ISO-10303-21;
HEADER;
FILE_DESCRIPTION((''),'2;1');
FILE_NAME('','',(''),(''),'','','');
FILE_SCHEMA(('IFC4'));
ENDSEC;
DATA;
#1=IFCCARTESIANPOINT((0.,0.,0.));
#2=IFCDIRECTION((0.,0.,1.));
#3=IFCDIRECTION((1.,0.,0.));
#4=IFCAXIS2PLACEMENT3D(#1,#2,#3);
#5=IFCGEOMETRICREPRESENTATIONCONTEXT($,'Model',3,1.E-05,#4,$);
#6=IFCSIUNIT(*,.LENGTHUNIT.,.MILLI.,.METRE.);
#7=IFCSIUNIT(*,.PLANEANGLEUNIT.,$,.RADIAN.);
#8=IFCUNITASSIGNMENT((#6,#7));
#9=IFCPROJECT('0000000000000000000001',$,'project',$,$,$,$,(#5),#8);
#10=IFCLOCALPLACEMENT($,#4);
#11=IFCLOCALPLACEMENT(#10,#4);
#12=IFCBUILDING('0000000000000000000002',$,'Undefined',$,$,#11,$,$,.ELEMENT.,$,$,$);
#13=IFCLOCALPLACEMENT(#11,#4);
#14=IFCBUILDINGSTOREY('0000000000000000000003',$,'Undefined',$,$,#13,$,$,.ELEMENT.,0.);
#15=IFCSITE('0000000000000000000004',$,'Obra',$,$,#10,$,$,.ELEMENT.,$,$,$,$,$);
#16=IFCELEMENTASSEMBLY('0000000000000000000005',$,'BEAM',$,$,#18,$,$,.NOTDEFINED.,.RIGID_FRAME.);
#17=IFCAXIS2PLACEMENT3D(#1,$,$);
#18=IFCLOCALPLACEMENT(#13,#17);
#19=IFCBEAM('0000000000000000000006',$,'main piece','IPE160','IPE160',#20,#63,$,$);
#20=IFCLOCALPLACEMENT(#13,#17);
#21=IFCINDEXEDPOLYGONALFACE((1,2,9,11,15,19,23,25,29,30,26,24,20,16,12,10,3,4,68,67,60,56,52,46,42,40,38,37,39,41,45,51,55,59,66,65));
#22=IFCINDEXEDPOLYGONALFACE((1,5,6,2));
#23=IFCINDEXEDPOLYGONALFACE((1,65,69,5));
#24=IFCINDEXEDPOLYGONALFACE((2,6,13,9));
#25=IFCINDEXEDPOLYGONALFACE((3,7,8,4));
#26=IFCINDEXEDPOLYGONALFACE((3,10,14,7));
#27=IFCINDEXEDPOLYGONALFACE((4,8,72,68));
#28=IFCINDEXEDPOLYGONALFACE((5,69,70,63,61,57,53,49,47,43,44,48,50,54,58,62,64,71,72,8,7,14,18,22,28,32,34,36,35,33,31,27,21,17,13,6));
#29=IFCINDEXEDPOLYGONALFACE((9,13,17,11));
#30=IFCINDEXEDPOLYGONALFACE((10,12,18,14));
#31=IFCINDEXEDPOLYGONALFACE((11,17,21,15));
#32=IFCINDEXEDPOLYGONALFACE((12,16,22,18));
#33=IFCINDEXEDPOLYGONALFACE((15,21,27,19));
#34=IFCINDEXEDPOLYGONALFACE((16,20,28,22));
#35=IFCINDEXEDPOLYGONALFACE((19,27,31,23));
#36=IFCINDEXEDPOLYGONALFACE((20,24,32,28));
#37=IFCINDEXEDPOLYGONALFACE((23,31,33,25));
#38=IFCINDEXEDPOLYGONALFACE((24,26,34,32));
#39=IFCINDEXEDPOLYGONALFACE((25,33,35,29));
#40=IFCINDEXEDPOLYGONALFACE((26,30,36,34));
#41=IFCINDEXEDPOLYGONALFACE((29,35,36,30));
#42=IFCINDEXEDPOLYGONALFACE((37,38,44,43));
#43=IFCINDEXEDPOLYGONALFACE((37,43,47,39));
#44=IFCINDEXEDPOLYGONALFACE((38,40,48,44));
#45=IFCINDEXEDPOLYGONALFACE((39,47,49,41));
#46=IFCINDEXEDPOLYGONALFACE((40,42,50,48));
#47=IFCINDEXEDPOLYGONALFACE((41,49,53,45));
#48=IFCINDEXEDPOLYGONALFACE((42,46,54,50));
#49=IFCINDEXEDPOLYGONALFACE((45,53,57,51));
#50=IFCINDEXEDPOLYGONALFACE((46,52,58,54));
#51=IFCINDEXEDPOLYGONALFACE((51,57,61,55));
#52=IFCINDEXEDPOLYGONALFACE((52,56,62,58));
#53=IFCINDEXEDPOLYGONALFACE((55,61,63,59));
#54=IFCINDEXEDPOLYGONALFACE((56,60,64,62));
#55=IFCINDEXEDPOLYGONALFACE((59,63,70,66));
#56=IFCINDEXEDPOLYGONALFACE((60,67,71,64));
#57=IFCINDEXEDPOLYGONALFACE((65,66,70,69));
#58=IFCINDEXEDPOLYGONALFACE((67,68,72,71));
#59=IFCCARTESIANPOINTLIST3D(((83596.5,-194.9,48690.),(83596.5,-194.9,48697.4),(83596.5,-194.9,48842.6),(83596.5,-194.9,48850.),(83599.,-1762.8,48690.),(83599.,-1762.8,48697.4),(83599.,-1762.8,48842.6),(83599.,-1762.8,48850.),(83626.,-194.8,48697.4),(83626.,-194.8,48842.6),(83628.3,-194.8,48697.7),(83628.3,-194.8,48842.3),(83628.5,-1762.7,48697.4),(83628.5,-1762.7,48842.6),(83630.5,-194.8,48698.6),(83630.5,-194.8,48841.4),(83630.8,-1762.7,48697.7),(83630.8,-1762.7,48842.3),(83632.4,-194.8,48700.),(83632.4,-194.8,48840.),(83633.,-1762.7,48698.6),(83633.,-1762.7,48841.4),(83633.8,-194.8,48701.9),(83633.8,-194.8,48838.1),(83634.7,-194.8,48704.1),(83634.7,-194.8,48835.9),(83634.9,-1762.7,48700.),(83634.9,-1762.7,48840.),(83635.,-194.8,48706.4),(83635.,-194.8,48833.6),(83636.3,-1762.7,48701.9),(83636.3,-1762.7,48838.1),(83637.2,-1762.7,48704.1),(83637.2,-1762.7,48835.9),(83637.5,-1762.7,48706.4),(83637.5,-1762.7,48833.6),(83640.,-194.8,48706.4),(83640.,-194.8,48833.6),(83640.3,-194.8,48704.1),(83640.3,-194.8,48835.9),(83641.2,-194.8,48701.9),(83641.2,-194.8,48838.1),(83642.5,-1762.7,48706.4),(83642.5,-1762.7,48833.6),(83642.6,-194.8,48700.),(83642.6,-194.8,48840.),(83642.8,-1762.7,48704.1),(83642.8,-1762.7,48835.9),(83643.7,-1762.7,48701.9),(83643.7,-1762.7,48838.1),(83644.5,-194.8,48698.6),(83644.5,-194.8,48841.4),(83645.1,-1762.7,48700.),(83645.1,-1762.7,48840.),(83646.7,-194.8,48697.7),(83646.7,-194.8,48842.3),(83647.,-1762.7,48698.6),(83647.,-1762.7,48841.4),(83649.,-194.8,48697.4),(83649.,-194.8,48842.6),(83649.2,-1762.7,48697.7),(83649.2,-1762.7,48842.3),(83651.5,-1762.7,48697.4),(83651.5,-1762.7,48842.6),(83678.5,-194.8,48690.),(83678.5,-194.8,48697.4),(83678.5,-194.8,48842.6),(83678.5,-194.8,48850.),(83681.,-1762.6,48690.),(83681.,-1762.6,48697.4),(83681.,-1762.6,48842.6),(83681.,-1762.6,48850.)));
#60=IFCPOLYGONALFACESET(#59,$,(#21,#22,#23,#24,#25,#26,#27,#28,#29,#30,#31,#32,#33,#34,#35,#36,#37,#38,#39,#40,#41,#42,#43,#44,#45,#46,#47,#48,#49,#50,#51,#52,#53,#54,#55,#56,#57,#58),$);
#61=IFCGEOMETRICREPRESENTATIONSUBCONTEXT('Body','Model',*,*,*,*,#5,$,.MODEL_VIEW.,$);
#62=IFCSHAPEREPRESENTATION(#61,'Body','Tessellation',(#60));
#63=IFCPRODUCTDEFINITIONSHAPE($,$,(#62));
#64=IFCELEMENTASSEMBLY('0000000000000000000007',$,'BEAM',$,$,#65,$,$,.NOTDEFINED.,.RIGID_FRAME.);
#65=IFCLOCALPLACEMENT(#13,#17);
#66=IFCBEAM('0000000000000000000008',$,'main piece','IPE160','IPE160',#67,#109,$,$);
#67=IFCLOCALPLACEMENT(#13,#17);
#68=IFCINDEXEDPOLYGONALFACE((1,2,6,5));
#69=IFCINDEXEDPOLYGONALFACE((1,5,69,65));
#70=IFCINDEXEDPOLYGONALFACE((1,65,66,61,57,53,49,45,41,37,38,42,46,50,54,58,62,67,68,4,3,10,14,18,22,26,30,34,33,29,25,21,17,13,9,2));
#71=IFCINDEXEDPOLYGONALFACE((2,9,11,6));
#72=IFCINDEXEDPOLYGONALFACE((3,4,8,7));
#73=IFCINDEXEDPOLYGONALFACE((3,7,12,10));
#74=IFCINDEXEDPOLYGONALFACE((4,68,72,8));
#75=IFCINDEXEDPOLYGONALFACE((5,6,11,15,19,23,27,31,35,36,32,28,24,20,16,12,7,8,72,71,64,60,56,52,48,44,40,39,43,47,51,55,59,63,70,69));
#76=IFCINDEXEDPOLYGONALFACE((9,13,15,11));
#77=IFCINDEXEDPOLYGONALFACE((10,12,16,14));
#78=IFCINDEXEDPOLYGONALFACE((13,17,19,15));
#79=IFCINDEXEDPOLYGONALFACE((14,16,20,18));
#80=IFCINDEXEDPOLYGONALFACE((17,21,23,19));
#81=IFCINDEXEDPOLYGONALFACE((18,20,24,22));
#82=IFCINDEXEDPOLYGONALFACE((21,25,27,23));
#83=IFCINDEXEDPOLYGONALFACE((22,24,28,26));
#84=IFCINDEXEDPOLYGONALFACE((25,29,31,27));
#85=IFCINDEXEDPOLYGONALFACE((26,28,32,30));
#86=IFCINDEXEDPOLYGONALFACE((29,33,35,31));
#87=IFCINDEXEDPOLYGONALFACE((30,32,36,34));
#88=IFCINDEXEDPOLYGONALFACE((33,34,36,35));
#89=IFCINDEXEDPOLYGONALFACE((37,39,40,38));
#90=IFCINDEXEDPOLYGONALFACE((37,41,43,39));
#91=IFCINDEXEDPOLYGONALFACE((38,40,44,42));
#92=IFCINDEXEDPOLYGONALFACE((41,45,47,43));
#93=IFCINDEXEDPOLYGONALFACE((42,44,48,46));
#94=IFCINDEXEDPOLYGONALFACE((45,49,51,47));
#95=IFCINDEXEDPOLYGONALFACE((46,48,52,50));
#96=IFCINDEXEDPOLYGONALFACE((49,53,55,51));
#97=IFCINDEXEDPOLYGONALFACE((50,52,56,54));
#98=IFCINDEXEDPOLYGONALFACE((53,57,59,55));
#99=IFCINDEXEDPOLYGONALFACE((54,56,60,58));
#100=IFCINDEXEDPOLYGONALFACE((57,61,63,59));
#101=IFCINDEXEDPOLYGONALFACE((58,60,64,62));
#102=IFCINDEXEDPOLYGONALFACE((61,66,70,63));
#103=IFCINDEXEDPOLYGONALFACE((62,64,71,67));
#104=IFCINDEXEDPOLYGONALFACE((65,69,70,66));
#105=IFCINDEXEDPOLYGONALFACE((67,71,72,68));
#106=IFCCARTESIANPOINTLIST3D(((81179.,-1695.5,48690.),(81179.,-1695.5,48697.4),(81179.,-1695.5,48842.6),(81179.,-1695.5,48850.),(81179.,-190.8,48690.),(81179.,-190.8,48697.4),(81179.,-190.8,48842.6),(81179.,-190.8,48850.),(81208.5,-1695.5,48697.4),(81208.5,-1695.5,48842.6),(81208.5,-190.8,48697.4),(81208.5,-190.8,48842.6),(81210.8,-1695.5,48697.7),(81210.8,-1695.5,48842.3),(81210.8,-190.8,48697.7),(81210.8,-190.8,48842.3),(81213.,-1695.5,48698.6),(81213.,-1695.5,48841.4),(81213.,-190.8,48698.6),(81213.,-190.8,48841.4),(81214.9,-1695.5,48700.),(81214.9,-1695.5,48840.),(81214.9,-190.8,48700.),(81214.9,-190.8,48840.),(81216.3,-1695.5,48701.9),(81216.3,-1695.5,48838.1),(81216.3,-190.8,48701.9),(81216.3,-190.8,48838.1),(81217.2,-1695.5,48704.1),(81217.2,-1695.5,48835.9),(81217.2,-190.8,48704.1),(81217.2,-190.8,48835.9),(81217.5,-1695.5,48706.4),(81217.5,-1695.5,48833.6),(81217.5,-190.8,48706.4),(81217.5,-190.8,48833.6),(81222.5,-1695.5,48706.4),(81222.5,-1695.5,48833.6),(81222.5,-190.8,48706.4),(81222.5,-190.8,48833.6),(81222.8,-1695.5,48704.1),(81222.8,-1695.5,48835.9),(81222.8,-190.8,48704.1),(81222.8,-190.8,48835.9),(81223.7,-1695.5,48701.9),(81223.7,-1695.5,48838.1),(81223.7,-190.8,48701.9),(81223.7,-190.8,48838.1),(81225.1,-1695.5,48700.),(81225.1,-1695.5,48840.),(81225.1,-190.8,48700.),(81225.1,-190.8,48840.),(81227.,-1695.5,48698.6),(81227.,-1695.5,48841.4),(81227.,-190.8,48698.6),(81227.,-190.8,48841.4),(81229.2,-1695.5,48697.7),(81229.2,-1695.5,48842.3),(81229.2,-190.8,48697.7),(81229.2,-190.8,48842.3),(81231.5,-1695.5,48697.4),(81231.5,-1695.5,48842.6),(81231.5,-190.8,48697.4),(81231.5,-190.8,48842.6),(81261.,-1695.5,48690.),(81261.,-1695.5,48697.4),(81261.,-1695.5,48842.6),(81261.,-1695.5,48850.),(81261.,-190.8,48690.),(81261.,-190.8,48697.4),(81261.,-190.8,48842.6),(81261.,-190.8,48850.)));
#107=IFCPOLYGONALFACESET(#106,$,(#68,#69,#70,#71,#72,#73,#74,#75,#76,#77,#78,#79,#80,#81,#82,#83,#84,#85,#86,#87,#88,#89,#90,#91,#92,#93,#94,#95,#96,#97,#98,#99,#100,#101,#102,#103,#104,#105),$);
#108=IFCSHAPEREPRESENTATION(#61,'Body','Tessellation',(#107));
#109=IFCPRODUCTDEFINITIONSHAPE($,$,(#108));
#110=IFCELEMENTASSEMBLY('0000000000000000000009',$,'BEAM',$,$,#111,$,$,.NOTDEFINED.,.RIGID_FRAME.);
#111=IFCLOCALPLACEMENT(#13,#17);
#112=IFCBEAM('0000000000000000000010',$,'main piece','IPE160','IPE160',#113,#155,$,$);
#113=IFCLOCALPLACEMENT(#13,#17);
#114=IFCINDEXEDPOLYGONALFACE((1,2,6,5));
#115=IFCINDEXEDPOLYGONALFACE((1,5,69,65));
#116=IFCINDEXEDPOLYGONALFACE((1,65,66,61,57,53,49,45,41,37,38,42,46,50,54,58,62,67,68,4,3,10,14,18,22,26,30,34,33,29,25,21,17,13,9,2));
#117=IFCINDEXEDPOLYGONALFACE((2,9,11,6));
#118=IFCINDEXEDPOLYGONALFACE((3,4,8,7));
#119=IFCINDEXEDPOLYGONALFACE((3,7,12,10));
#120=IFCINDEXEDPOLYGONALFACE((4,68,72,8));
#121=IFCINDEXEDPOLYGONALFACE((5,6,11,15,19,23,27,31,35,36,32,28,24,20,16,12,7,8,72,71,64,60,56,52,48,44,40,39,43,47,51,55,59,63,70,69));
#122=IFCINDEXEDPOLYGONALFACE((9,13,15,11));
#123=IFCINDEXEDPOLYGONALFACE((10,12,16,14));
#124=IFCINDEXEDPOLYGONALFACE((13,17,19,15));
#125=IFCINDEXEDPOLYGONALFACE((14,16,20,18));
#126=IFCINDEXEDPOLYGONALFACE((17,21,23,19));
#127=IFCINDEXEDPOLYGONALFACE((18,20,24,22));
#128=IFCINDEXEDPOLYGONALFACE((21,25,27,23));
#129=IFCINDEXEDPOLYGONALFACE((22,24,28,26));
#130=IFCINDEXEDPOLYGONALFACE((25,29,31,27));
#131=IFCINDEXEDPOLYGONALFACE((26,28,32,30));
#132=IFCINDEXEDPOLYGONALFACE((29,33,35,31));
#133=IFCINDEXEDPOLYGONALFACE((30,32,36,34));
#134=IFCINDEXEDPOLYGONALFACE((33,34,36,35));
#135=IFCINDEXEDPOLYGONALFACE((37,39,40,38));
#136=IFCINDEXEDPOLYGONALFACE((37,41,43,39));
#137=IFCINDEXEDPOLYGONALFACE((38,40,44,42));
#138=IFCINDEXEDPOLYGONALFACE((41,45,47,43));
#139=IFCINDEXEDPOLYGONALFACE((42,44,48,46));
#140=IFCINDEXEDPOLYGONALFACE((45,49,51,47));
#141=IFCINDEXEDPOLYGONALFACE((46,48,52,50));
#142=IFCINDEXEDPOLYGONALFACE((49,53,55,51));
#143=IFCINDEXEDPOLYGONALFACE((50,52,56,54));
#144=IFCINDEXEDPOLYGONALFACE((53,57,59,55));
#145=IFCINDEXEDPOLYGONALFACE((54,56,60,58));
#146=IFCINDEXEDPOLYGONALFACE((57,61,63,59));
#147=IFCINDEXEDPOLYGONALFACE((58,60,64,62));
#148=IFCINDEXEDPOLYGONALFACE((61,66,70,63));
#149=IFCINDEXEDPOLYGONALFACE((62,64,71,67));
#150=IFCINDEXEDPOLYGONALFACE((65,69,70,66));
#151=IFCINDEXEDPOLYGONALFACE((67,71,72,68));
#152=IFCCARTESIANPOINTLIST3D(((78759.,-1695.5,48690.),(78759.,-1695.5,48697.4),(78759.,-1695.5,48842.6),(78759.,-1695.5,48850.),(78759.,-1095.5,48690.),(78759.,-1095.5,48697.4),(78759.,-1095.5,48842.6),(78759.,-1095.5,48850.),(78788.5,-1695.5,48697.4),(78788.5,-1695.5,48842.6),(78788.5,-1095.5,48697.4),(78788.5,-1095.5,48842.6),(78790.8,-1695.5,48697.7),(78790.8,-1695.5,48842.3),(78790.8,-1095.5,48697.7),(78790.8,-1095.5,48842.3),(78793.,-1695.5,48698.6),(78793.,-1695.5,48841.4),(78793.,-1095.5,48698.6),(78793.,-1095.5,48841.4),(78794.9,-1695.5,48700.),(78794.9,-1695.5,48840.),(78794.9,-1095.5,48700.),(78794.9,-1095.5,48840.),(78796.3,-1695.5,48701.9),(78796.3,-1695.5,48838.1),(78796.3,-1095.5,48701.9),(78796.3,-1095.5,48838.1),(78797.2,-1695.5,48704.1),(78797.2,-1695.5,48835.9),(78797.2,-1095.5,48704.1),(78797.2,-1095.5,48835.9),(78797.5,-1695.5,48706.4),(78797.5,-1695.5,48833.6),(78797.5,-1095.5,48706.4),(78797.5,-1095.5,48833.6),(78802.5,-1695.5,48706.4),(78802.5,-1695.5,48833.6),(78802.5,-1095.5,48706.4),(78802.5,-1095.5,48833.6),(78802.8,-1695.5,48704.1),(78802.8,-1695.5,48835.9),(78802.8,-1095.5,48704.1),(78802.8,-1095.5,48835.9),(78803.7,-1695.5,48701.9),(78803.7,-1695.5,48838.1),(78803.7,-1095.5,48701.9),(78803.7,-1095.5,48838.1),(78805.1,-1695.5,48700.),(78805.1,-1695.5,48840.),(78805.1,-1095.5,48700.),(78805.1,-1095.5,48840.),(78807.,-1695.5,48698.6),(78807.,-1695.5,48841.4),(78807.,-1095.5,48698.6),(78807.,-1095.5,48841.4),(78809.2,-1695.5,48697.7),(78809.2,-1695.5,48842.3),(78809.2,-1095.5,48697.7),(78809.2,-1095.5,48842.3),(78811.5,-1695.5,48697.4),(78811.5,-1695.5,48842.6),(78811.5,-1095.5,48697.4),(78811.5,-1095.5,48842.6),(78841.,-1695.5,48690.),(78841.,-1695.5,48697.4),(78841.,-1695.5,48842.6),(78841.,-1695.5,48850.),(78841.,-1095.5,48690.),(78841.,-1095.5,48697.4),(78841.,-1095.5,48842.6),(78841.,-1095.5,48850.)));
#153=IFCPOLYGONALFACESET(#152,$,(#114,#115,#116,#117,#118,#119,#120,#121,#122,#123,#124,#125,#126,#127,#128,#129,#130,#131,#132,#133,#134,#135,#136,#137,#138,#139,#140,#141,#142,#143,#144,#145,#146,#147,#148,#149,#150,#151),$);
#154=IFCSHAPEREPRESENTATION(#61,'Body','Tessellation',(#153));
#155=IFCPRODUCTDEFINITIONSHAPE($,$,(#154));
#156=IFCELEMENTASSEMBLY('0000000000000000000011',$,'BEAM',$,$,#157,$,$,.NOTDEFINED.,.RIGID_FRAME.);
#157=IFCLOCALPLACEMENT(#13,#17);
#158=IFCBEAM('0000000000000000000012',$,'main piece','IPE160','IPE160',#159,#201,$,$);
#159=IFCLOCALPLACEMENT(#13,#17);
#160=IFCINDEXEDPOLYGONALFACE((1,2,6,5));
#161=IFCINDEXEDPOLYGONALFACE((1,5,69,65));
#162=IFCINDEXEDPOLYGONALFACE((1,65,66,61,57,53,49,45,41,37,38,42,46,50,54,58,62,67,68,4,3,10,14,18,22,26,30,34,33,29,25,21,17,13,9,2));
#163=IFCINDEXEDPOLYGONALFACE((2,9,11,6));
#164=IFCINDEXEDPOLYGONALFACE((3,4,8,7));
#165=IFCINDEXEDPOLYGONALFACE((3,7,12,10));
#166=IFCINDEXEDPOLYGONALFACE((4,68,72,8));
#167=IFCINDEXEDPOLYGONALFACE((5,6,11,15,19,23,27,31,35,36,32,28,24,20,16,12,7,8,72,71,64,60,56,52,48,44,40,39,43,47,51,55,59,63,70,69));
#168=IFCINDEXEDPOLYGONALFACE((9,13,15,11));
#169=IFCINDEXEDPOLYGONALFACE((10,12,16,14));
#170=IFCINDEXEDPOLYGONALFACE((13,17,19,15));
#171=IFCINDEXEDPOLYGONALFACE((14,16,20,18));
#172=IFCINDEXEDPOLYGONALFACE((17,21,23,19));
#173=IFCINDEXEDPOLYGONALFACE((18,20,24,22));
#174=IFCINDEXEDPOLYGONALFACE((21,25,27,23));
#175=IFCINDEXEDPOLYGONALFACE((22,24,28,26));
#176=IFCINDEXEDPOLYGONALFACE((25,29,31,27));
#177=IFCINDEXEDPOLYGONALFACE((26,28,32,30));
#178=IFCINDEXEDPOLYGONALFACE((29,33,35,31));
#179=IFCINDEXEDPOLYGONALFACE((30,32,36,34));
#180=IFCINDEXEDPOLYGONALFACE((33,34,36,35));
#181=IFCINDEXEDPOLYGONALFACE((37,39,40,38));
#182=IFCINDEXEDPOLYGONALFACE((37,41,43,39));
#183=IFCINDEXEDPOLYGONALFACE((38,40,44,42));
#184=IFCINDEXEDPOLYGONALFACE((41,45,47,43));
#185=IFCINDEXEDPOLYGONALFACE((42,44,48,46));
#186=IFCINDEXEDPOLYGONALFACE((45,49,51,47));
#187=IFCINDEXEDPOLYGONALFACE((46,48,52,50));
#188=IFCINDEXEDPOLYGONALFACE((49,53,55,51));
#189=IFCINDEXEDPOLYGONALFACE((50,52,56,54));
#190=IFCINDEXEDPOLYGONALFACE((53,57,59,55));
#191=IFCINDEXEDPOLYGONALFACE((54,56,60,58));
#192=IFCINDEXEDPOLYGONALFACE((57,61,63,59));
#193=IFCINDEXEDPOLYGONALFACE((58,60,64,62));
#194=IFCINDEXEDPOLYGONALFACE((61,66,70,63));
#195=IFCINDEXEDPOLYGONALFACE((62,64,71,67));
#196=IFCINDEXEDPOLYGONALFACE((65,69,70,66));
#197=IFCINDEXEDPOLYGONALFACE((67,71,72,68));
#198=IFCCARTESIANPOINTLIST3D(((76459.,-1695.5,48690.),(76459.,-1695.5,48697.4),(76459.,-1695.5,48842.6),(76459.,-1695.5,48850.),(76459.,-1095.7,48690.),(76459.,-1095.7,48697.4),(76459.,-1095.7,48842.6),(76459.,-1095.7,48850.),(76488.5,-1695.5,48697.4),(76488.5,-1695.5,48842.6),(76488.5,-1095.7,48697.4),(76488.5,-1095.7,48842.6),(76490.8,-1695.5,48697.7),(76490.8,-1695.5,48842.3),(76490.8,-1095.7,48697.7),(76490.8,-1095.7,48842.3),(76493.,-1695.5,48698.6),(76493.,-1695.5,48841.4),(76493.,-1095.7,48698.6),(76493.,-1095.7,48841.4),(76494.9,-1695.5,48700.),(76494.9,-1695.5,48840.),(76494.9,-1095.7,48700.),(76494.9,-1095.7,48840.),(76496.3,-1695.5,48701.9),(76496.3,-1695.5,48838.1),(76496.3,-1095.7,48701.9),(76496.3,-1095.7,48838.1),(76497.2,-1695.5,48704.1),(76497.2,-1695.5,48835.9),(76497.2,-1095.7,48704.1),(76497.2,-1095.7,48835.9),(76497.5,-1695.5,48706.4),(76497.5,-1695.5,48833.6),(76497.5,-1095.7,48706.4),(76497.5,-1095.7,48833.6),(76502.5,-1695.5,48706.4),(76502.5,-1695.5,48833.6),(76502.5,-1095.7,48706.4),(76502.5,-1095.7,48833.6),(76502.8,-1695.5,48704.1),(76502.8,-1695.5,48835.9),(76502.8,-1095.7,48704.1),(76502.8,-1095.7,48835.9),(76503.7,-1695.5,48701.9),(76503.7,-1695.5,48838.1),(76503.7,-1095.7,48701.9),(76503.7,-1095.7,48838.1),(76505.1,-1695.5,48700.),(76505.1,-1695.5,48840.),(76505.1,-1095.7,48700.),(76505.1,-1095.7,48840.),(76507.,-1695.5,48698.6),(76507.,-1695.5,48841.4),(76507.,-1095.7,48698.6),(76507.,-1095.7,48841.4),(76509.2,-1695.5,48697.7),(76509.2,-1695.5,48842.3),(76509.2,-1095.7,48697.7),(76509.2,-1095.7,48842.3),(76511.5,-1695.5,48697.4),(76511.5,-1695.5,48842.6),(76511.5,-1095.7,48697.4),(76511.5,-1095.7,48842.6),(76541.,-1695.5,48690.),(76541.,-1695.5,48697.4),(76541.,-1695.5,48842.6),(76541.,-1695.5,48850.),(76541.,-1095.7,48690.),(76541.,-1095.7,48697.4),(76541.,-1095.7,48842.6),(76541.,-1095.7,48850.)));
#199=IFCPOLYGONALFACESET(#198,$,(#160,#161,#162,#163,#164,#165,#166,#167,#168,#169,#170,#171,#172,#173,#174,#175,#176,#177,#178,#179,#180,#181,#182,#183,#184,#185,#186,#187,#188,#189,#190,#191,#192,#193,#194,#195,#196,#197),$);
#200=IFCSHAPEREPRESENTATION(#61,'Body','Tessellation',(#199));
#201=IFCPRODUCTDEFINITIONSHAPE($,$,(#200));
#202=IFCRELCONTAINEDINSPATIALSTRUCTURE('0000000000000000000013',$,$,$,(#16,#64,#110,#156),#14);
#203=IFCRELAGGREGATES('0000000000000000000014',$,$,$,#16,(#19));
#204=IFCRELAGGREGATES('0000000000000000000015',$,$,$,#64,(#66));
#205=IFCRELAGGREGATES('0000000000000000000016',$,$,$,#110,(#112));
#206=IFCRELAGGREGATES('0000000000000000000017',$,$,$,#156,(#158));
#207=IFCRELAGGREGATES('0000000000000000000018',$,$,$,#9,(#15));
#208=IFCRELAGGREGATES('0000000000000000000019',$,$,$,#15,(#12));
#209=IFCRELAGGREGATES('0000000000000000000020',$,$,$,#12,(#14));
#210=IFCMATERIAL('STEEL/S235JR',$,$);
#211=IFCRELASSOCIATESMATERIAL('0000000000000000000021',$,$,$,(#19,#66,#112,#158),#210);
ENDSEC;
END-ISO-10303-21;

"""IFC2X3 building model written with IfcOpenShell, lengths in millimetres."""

from ifc_helpers import new_model, si_unit, frame, origin_with_axes, origin_2d_with_axis, place, context, subcontext, project, spatial, i_section, extrude, material, element, aggregate, save


model = new_model("IFC2X3")

# Units and contexts
model_context = context("Model", 3, precision=1e-05, world=origin_with_axes())
body_context = subcontext(model_context, "Body", "Model", "MODEL_VIEW")
ifc_project = project(units=[si_unit("LENGTHUNIT", "METRE", prefix="MILLI"), si_unit("PLANEANGLEUNIT", "RADIAN")], contexts=[model_context])

# Site, building, storey
site_placement = place(None, origin_with_axes())
site = spatial("IfcSite", under=ifc_project, at=site_placement, Name="Obra", CompositionType="ELEMENT")
building_placement = place(site_placement, origin_with_axes())
building = spatial("IfcBuilding", under=site, at=building_placement, Name="Undefined", CompositionType="ELEMENT")
storey_placement = place(building_placement, origin_with_axes())
storey = spatial("IfcBuildingStorey", under=building, at=storey_placement, Name="Undefined", CompositionType="ELEMENT", Elevation=0.0)

# Shared definitions
ifc_material_1 = material(Name="STEEL/S235JR")

# Element assemblies, beams
assembly_1_placement = place(storey_placement, origin_with_axes())
assembly_1 = element("IfcElementAssembly", 1, at=assembly_1_placement, inside=storey, Name="BEAM", AssemblyPlace="NOTDEFINED", PredefinedType="RIGID_FRAME")
beam_1_placement = place(assembly_1_placement, frame((83637.5, -194.8, 48770.0), z_axis=(0.0, 0.0, 1.0), x_axis=(0.001595, -0.999999, 0.0)))
beam_1 = element("IfcBeam", 2, at=beam_1_placement, material=ifc_material_1, Name="main piece", Description="IPE160", ObjectType="IPE160", context=body_context, shape_type="SweptSolid", body=[
    extrude(i_section(OverallWidth=82.0, OverallDepth=160.0, WebThickness=5.0, FlangeThickness=7.4, FilletRadius=9.0, at=origin_2d_with_axis()), frame((1567.9, 0.0, 0.0), z_axis=(-1.0, 0.0, 0.0), x_axis=(0.0, -1.0, 0.0)), (0.0, 0.0, 1.0), 1567.9),
])
aggregate(assembly_1, [beam_1])
assembly_2_placement = place(storey_placement, origin_with_axes())
assembly_2 = element("IfcElementAssembly", 3, at=assembly_2_placement, inside=storey, Name="BEAM", AssemblyPlace="NOTDEFINED", PredefinedType="RIGID_FRAME")
beam_2_placement = place(assembly_2_placement, frame((81220.0, -190.8, 48770.0), z_axis=(0.0, 0.0, 1.0), x_axis=(-0.000003, -1.0, 0.0)))
beam_2 = element("IfcBeam", 4, at=beam_2_placement, material=ifc_material_1, Name="main piece", Description="IPE160", ObjectType="IPE160", context=body_context, shape_type="SweptSolid", body=[
    extrude(i_section(OverallWidth=82.0, OverallDepth=160.0, WebThickness=5.0, FlangeThickness=7.4, FilletRadius=9.0, at=origin_2d_with_axis()), frame((1504.7, 0.0, 0.0), z_axis=(-1.0, 0.0, 0.0), x_axis=(0.0, -1.0, 0.0)), (0.0, 0.0, 1.0), 1504.7),
])
aggregate(assembly_2, [beam_2])
assembly_3_placement = place(storey_placement, origin_with_axes())
assembly_3 = element("IfcElementAssembly", 5, at=assembly_3_placement, inside=storey, Name="BEAM", AssemblyPlace="NOTDEFINED", PredefinedType="RIGID_FRAME")
beam_3_placement = place(assembly_3_placement, frame((78800.0, -1095.5, 48770.0), z_axis=(0.0, 0.0, 1.0), x_axis=(0.0, -1.0, 0.0)))
beam_3 = element("IfcBeam", 6, at=beam_3_placement, material=ifc_material_1, Name="main piece", Description="IPE160", ObjectType="IPE160", context=body_context, shape_type="SweptSolid", body=[
    extrude(i_section(OverallWidth=82.0, OverallDepth=160.0, WebThickness=5.0, FlangeThickness=7.4, FilletRadius=9.0, at=origin_2d_with_axis()), frame((600.1, 0.0, 0.0), z_axis=(-1.0, 0.0, 0.0), x_axis=(0.0, -1.0, 0.0)), (0.0, 0.0, 1.0), 600.0),
])
aggregate(assembly_3, [beam_3])
assembly_4_placement = place(storey_placement, origin_with_axes())
assembly_4 = element("IfcElementAssembly", 7, at=assembly_4_placement, inside=storey, Name="BEAM", AssemblyPlace="NOTDEFINED", PredefinedType="RIGID_FRAME")
beam_4_placement = place(assembly_4_placement, frame((76500.0, -1095.7, 48770.0), z_axis=(0.0, 0.0, 1.0), x_axis=(0.0, -1.0, 0.0)))
beam_4 = element("IfcBeam", 8, at=beam_4_placement, material=ifc_material_1, Name="main piece", Description="IPE160", ObjectType="IPE160", context=body_context, shape_type="SweptSolid", body=[
    extrude(i_section(OverallWidth=82.0, OverallDepth=160.0, WebThickness=5.0, FlangeThickness=7.4, FilletRadius=9.0, at=origin_2d_with_axis()), frame((599.8, 0.0, 0.0), z_axis=(-1.0, 0.0, 0.0), x_axis=(0.0, -1.0, 0.0)), (0.0, 0.0, 1.0), 599.8),
])
aggregate(assembly_4, [beam_4])

save(model, "model.ifc")
